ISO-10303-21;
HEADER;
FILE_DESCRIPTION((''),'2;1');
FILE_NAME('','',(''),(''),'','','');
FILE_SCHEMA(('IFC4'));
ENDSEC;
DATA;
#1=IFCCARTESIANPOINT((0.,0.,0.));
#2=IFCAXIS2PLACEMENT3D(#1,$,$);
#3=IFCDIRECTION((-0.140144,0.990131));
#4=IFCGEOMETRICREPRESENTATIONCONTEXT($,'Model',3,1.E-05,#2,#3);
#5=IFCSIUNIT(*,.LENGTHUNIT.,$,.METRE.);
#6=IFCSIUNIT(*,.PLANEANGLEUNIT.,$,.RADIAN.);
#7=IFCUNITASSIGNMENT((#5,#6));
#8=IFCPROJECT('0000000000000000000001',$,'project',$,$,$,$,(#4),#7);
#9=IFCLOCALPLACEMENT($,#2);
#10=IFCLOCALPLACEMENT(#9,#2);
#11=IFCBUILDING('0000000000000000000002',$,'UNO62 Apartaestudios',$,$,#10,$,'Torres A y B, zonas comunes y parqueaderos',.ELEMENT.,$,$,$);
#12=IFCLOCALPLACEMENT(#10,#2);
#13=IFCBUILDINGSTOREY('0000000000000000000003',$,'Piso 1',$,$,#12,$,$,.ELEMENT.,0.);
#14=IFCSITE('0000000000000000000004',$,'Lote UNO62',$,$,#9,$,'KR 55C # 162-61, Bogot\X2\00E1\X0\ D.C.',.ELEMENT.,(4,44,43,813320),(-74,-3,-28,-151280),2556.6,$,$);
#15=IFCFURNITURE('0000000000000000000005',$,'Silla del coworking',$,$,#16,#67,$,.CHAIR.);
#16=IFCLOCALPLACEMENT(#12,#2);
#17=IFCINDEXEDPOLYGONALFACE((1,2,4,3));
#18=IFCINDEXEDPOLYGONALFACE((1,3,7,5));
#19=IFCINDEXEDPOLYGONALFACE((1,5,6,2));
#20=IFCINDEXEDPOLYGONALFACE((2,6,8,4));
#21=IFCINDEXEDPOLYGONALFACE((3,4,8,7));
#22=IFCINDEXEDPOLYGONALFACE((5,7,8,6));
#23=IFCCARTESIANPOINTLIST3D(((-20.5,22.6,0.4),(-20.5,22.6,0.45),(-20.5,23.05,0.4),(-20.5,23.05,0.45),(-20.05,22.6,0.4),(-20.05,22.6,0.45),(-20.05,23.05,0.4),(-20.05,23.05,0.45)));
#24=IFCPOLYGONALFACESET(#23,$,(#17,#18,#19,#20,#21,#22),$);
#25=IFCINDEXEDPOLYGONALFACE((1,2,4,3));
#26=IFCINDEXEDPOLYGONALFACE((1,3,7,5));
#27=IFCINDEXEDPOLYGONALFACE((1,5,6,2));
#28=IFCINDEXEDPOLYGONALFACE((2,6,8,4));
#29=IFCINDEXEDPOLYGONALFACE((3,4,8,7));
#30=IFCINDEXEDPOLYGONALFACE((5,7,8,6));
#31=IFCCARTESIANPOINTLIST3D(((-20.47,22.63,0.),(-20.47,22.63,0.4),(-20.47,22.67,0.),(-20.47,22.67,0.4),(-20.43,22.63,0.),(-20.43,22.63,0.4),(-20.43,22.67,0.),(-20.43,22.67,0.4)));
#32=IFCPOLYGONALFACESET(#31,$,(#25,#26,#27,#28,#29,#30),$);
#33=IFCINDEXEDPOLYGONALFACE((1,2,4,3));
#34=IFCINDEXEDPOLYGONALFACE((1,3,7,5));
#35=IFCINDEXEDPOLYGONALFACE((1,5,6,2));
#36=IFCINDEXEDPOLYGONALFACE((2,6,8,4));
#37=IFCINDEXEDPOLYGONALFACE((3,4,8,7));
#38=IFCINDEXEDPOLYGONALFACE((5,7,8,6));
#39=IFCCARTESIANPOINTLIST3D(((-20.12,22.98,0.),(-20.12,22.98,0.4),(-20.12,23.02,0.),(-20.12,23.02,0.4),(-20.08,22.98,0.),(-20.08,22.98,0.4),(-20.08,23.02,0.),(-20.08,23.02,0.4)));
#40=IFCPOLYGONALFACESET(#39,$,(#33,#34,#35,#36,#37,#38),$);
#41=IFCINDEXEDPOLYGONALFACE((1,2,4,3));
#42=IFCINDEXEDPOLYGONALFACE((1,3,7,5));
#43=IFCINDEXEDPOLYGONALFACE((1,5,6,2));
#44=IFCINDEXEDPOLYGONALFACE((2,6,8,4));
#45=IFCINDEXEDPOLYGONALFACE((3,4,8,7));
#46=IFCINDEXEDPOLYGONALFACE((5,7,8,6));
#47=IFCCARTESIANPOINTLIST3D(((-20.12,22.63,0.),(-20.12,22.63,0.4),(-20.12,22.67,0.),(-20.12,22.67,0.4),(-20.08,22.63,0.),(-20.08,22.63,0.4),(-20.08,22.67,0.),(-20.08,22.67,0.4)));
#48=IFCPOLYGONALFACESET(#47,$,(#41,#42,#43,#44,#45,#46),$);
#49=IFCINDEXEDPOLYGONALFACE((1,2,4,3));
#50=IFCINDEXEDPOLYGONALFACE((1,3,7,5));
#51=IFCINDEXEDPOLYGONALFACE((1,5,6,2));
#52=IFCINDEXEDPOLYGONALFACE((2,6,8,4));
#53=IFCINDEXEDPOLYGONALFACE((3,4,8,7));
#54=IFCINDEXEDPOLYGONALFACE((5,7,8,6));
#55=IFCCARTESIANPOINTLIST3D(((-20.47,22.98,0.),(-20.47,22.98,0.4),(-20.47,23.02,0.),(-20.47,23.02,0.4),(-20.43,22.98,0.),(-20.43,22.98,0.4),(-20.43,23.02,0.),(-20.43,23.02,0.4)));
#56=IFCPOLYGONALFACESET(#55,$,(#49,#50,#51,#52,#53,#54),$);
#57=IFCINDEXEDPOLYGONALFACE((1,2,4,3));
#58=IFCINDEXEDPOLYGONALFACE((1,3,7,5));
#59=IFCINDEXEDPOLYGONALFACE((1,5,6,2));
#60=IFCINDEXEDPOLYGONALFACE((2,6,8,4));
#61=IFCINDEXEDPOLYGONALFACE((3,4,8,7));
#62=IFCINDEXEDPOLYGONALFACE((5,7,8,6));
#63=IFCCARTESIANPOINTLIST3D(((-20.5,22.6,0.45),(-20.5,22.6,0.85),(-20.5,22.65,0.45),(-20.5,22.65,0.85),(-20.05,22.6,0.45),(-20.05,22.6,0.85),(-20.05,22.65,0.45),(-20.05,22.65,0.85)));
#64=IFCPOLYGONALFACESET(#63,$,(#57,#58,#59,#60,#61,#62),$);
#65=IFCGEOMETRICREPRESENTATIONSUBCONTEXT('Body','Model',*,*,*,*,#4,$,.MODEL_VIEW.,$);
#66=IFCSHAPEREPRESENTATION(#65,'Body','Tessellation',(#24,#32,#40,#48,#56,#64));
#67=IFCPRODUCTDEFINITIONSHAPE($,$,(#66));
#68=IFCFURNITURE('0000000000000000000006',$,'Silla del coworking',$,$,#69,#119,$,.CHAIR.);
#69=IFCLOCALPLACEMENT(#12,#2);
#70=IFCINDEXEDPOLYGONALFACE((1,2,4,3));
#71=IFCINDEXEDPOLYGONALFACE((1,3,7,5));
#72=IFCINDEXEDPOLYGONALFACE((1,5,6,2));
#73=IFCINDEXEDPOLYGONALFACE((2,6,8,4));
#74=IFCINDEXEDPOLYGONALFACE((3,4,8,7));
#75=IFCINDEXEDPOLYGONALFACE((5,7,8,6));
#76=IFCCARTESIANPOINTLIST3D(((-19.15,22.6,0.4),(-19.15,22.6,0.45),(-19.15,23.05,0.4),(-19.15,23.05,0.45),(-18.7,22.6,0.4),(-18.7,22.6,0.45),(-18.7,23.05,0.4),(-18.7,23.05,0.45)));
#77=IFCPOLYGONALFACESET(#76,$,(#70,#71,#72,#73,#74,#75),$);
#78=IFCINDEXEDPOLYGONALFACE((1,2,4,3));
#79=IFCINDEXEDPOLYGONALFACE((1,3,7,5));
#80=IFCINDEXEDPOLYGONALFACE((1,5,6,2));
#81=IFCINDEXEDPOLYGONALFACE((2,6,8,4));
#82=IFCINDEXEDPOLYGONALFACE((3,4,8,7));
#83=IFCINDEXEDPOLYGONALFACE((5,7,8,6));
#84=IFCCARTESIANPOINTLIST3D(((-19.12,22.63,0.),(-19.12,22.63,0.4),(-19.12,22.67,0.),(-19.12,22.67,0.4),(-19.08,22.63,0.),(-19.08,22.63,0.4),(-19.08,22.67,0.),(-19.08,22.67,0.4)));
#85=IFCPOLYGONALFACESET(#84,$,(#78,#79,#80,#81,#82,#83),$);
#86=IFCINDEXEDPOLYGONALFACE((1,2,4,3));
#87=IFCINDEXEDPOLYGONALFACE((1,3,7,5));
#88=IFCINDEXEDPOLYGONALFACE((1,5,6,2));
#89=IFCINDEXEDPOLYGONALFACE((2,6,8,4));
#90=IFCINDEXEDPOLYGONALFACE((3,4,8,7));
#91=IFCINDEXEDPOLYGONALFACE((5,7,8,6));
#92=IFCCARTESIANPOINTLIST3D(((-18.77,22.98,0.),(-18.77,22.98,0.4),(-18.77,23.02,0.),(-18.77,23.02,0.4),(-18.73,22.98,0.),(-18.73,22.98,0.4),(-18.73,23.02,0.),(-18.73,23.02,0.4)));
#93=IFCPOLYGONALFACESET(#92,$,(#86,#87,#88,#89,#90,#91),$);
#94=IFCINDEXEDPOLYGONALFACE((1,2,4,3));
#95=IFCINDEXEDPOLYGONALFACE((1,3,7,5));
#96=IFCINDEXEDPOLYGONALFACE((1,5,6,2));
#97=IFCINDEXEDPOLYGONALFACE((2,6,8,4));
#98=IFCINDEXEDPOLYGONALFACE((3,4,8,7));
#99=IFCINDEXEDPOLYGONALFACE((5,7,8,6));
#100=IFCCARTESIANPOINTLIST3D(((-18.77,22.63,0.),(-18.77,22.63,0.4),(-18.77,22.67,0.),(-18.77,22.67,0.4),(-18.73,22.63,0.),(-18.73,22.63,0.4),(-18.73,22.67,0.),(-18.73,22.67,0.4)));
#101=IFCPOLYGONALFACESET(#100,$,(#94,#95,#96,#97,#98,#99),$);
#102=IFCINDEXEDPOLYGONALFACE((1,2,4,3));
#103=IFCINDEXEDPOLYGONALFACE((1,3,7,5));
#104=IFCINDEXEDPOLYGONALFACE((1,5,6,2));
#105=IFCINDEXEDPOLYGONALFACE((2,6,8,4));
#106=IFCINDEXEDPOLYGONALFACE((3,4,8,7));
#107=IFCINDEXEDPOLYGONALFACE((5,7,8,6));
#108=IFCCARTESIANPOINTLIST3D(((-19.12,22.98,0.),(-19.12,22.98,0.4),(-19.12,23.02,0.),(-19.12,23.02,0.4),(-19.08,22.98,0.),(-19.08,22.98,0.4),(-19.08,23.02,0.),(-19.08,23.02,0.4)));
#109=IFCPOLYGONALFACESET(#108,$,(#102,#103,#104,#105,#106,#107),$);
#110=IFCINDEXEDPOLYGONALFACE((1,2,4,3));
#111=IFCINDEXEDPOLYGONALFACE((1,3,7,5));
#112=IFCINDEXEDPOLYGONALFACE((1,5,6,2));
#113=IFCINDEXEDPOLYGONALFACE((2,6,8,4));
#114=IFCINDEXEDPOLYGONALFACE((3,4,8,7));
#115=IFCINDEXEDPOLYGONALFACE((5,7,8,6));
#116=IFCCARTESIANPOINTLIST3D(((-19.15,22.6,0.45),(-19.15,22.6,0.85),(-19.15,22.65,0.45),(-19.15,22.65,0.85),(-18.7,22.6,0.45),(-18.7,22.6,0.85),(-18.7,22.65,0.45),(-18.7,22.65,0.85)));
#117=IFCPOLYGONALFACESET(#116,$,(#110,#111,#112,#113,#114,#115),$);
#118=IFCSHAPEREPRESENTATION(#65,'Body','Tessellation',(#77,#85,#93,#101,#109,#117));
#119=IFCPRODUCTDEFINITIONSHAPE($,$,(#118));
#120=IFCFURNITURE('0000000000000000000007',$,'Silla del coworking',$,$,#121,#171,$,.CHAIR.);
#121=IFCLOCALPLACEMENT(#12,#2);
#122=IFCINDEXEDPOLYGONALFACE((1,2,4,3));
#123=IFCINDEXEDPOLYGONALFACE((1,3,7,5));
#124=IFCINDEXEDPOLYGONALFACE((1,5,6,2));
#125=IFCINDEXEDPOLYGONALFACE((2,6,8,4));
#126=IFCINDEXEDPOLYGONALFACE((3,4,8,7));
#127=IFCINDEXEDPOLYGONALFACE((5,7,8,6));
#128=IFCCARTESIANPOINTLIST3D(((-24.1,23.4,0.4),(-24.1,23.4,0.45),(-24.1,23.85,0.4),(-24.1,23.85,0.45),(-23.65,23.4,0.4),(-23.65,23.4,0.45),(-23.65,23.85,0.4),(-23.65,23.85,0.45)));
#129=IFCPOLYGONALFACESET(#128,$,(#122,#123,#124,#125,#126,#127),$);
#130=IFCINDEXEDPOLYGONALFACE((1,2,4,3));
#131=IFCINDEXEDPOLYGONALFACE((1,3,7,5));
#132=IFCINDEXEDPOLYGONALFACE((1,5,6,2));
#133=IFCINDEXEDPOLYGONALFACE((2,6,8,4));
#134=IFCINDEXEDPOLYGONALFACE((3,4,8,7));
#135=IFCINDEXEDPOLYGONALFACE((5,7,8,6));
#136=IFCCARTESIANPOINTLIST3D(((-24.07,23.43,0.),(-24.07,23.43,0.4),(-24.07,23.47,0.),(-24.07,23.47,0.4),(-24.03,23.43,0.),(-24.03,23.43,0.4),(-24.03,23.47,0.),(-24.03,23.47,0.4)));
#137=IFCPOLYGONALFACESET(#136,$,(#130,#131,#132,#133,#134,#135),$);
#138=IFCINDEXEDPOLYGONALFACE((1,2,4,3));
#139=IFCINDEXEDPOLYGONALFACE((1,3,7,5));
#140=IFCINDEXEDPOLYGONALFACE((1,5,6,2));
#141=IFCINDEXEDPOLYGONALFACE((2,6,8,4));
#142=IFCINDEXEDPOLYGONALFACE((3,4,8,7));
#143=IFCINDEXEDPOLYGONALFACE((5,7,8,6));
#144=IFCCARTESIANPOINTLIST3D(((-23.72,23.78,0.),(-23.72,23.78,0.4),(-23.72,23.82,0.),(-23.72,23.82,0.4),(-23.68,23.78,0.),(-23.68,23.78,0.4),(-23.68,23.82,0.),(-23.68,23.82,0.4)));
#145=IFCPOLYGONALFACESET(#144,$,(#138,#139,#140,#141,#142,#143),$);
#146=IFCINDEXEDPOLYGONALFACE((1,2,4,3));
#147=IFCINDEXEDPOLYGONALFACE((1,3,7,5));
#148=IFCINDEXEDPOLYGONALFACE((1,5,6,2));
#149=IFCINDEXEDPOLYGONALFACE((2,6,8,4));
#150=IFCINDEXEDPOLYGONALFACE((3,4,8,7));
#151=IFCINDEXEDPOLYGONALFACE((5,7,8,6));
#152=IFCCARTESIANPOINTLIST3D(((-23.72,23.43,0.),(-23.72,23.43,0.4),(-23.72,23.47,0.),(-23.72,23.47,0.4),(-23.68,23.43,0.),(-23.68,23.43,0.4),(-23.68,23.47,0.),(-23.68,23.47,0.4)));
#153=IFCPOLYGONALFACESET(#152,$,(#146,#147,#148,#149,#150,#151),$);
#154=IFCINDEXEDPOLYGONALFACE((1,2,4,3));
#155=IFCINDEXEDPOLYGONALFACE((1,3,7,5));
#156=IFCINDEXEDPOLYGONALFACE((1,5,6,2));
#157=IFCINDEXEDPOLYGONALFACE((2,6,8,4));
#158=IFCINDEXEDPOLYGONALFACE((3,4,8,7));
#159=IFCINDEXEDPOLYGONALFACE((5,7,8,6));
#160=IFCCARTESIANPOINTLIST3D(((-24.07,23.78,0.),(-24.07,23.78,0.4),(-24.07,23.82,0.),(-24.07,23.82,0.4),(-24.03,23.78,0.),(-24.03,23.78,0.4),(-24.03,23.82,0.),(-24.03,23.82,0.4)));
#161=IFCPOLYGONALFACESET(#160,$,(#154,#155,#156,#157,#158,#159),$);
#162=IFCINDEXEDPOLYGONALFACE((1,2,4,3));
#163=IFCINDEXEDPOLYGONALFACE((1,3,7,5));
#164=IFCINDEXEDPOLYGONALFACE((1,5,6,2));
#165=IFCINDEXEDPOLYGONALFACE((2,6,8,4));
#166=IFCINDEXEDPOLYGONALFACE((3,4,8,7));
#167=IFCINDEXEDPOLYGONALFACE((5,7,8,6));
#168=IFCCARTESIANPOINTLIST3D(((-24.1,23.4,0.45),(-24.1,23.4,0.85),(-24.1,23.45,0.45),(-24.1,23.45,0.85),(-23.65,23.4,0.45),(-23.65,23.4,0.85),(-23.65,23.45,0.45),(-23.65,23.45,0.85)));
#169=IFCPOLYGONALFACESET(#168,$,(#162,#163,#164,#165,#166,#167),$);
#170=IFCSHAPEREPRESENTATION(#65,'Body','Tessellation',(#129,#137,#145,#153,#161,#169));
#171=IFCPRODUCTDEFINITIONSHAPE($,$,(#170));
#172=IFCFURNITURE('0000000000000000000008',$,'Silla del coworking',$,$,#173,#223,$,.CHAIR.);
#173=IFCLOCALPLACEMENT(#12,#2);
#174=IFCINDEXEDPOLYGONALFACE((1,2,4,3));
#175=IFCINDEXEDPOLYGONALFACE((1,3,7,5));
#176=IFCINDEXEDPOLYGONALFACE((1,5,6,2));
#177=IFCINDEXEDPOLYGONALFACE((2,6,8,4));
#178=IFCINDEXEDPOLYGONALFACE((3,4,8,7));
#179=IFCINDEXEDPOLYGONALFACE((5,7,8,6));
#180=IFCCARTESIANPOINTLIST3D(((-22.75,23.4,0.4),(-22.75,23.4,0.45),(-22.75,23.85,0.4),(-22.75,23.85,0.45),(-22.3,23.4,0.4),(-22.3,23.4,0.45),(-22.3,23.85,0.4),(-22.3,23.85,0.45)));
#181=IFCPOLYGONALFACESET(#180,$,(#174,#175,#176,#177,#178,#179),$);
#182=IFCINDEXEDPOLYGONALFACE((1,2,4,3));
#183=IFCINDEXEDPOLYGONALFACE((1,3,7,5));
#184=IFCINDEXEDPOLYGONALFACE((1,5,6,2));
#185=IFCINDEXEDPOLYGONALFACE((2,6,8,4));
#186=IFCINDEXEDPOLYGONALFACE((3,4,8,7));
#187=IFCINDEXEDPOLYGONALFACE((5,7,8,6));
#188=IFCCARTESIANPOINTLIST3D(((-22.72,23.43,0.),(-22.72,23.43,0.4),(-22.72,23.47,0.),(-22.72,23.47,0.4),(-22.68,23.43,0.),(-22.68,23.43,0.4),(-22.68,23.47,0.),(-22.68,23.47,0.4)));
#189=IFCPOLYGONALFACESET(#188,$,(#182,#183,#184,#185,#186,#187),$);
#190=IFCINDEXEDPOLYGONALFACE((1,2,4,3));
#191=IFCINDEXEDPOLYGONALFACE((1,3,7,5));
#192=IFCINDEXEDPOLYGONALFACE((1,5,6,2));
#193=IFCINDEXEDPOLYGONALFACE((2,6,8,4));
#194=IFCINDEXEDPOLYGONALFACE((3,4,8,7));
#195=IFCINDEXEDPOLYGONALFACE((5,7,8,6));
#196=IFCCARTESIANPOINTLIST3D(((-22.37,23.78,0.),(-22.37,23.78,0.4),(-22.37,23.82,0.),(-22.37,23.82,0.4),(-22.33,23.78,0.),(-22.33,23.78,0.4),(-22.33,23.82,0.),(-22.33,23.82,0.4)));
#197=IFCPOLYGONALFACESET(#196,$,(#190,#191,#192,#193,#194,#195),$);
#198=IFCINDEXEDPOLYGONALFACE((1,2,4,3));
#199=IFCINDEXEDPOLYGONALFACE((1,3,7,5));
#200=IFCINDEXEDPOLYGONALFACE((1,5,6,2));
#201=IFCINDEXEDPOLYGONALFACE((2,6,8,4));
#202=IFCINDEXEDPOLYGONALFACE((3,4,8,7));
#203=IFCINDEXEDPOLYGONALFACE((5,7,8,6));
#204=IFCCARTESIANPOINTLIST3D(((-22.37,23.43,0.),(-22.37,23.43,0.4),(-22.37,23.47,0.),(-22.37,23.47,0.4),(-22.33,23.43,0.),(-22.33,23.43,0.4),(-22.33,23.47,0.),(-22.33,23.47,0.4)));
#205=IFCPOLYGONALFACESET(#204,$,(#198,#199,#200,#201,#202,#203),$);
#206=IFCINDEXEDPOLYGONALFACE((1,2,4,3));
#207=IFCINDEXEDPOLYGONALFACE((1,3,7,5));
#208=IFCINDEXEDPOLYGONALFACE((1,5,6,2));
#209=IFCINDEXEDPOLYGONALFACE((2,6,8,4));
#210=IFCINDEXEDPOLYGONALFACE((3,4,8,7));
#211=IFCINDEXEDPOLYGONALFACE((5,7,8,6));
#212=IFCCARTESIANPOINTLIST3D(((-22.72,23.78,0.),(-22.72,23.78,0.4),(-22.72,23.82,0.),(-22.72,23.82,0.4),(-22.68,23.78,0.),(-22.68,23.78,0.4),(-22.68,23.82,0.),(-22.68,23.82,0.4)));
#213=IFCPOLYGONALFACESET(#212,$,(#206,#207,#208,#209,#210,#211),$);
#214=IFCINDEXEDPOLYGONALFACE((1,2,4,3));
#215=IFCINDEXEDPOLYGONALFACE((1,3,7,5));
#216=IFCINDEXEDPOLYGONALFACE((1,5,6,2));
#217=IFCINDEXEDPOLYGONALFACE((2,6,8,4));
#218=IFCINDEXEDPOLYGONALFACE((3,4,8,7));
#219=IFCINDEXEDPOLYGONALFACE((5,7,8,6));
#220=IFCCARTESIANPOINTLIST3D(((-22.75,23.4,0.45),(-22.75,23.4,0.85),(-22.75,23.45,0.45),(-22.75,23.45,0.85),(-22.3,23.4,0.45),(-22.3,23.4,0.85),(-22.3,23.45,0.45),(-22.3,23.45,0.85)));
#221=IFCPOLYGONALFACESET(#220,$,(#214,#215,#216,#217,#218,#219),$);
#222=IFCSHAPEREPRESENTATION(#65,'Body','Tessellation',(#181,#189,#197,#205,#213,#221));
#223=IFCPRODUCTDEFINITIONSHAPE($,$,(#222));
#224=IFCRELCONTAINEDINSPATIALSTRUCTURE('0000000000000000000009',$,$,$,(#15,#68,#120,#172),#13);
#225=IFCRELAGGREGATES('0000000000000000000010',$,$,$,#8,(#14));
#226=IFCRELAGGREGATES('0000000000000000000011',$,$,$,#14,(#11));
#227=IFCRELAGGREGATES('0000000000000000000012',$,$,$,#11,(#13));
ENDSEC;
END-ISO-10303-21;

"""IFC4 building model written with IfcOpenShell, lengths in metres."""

from ifc_helpers import new_model, si_unit, direction, frame, frame_2d, origin, place, context, subcontext, project, spatial, rectangle, extrude, element, save


model = new_model("IFC4")

# Units and contexts
model_context = context("Model", 3, precision=1e-05, world=origin(), true_north=direction((-0.140144, 0.990131)))
body_context = subcontext(model_context, "Body", "Model", "MODEL_VIEW")
ifc_project = project(units=[si_unit("LENGTHUNIT", "METRE"), si_unit("PLANEANGLEUNIT", "RADIAN")], contexts=[model_context])

# Site, building, storey
site_placement = place(None, origin())
site = spatial("IfcSite", under=ifc_project, at=site_placement, Name="Lote UNO62", LongName="KR 55C # 162-61, Bogotá D.C.", CompositionType="ELEMENT", RefLatitude=(4, 44, 43, 813320), RefLongitude=(-74, -3, -28, -151280), RefElevation=2556.6)
building_placement = place(site_placement, origin())
building = spatial("IfcBuilding", under=site, at=building_placement, Name="UNO62 Apartaestudios", LongName="Torres A y B, zonas comunes y parqueaderos", CompositionType="ELEMENT")
storey_placement = place(building_placement, origin())
storey = spatial("IfcBuildingStorey", under=building, at=storey_placement, Name="Piso 1", CompositionType="ELEMENT", Elevation=0.0)

# Furniture
furniture_1_placement = place(storey_placement, origin())
element("IfcFurniture", 1, at=furniture_1_placement, inside=storey, Name="Silla del coworking", PredefinedType="CHAIR", context=body_context, shape_type="SweptSolid", body=[
    extrude(rectangle(XDim=0.45, YDim=0.45, at=frame_2d((-20.275, 22.825))), frame((0.0, 0.0, 0.4)), (0.0, 0.0, 1.0), 0.05),
    extrude(rectangle(XDim=0.04, YDim=0.04, at=frame_2d((-20.45, 22.65))), origin(), (0.0, 0.0, 1.0), 0.4),
    extrude(rectangle(XDim=0.04, YDim=0.04, at=frame_2d((-20.1, 23.0))), origin(), (0.0, 0.0, 1.0), 0.4),
    extrude(rectangle(XDim=0.04, YDim=0.04, at=frame_2d((-20.1, 22.65))), origin(), (0.0, 0.0, 1.0), 0.4),
    extrude(rectangle(XDim=0.04, YDim=0.04, at=frame_2d((-20.45, 23.0))), origin(), (0.0, 0.0, 1.0), 0.4),
    extrude(rectangle(XDim=0.45, YDim=0.05, at=frame_2d((-20.275, 22.625))), frame((0.0, 0.0, 0.45)), (0.0, 0.0, 1.0), 0.4),
])
furniture_2_placement = place(storey_placement, origin())
element("IfcFurniture", 2, at=furniture_2_placement, inside=storey, Name="Silla del coworking", PredefinedType="CHAIR", context=body_context, shape_type="SweptSolid", body=[
    extrude(rectangle(XDim=0.45, YDim=0.45, at=frame_2d((-18.925, 22.825))), frame((0.0, 0.0, 0.4)), (0.0, 0.0, 1.0), 0.05),
    extrude(rectangle(XDim=0.04, YDim=0.04, at=frame_2d((-19.1, 22.65))), origin(), (0.0, 0.0, 1.0), 0.4),
    extrude(rectangle(XDim=0.04, YDim=0.04, at=frame_2d((-18.75, 23.0))), origin(), (0.0, 0.0, 1.0), 0.4),
    extrude(rectangle(XDim=0.04, YDim=0.04, at=frame_2d((-18.75, 22.65))), origin(), (0.0, 0.0, 1.0), 0.4),
    extrude(rectangle(XDim=0.04, YDim=0.04, at=frame_2d((-19.1, 23.0))), origin(), (0.0, 0.0, 1.0), 0.4),
    extrude(rectangle(XDim=0.45, YDim=0.05, at=frame_2d((-18.925, 22.625))), frame((0.0, 0.0, 0.45)), (0.0, 0.0, 1.0), 0.4),
])
furniture_3_placement = place(storey_placement, origin())
element("IfcFurniture", 3, at=furniture_3_placement, inside=storey, Name="Silla del coworking", PredefinedType="CHAIR", context=body_context, shape_type="SweptSolid", body=[
    extrude(rectangle(XDim=0.45, YDim=0.45, at=frame_2d((-23.875, 23.625))), frame((0.0, 0.0, 0.4)), (0.0, 0.0, 1.0), 0.05),
    extrude(rectangle(XDim=0.04, YDim=0.04, at=frame_2d((-24.05, 23.45))), origin(), (0.0, 0.0, 1.0), 0.4),
    extrude(rectangle(XDim=0.04, YDim=0.04, at=frame_2d((-23.7, 23.8))), origin(), (0.0, 0.0, 1.0), 0.4),
    extrude(rectangle(XDim=0.04, YDim=0.04, at=frame_2d((-23.7, 23.45))), origin(), (0.0, 0.0, 1.0), 0.4),
    extrude(rectangle(XDim=0.04, YDim=0.04, at=frame_2d((-24.05, 23.8))), origin(), (0.0, 0.0, 1.0), 0.4),
    extrude(rectangle(XDim=0.45, YDim=0.05, at=frame_2d((-23.875, 23.425))), frame((0.0, 0.0, 0.45)), (0.0, 0.0, 1.0), 0.4),
])
furniture_4_placement = place(storey_placement, origin())
element("IfcFurniture", 4, at=furniture_4_placement, inside=storey, Name="Silla del coworking", PredefinedType="CHAIR", context=body_context, shape_type="SweptSolid", body=[
    extrude(rectangle(XDim=0.45, YDim=0.45, at=frame_2d((-22.525, 23.625))), frame((0.0, 0.0, 0.4)), (0.0, 0.0, 1.0), 0.05),
    extrude(rectangle(XDim=0.04, YDim=0.04, at=frame_2d((-22.7, 23.45))), origin(), (0.0, 0.0, 1.0), 0.4),
    extrude(rectangle(XDim=0.04, YDim=0.04, at=frame_2d((-22.35, 23.8))), origin(), (0.0, 0.0, 1.0), 0.4),
    extrude(rectangle(XDim=0.04, YDim=0.04, at=frame_2d((-22.35, 23.45))), origin(), (0.0, 0.0, 1.0), 0.4),
    extrude(rectangle(XDim=0.04, YDim=0.04, at=frame_2d((-22.7, 23.8))), origin(), (0.0, 0.0, 1.0), 0.4),
    extrude(rectangle(XDim=0.45, YDim=0.05, at=frame_2d((-22.525, 23.425))), frame((0.0, 0.0, 0.45)), (0.0, 0.0, 1.0), 0.4),
])

save(model, "model.ifc")
